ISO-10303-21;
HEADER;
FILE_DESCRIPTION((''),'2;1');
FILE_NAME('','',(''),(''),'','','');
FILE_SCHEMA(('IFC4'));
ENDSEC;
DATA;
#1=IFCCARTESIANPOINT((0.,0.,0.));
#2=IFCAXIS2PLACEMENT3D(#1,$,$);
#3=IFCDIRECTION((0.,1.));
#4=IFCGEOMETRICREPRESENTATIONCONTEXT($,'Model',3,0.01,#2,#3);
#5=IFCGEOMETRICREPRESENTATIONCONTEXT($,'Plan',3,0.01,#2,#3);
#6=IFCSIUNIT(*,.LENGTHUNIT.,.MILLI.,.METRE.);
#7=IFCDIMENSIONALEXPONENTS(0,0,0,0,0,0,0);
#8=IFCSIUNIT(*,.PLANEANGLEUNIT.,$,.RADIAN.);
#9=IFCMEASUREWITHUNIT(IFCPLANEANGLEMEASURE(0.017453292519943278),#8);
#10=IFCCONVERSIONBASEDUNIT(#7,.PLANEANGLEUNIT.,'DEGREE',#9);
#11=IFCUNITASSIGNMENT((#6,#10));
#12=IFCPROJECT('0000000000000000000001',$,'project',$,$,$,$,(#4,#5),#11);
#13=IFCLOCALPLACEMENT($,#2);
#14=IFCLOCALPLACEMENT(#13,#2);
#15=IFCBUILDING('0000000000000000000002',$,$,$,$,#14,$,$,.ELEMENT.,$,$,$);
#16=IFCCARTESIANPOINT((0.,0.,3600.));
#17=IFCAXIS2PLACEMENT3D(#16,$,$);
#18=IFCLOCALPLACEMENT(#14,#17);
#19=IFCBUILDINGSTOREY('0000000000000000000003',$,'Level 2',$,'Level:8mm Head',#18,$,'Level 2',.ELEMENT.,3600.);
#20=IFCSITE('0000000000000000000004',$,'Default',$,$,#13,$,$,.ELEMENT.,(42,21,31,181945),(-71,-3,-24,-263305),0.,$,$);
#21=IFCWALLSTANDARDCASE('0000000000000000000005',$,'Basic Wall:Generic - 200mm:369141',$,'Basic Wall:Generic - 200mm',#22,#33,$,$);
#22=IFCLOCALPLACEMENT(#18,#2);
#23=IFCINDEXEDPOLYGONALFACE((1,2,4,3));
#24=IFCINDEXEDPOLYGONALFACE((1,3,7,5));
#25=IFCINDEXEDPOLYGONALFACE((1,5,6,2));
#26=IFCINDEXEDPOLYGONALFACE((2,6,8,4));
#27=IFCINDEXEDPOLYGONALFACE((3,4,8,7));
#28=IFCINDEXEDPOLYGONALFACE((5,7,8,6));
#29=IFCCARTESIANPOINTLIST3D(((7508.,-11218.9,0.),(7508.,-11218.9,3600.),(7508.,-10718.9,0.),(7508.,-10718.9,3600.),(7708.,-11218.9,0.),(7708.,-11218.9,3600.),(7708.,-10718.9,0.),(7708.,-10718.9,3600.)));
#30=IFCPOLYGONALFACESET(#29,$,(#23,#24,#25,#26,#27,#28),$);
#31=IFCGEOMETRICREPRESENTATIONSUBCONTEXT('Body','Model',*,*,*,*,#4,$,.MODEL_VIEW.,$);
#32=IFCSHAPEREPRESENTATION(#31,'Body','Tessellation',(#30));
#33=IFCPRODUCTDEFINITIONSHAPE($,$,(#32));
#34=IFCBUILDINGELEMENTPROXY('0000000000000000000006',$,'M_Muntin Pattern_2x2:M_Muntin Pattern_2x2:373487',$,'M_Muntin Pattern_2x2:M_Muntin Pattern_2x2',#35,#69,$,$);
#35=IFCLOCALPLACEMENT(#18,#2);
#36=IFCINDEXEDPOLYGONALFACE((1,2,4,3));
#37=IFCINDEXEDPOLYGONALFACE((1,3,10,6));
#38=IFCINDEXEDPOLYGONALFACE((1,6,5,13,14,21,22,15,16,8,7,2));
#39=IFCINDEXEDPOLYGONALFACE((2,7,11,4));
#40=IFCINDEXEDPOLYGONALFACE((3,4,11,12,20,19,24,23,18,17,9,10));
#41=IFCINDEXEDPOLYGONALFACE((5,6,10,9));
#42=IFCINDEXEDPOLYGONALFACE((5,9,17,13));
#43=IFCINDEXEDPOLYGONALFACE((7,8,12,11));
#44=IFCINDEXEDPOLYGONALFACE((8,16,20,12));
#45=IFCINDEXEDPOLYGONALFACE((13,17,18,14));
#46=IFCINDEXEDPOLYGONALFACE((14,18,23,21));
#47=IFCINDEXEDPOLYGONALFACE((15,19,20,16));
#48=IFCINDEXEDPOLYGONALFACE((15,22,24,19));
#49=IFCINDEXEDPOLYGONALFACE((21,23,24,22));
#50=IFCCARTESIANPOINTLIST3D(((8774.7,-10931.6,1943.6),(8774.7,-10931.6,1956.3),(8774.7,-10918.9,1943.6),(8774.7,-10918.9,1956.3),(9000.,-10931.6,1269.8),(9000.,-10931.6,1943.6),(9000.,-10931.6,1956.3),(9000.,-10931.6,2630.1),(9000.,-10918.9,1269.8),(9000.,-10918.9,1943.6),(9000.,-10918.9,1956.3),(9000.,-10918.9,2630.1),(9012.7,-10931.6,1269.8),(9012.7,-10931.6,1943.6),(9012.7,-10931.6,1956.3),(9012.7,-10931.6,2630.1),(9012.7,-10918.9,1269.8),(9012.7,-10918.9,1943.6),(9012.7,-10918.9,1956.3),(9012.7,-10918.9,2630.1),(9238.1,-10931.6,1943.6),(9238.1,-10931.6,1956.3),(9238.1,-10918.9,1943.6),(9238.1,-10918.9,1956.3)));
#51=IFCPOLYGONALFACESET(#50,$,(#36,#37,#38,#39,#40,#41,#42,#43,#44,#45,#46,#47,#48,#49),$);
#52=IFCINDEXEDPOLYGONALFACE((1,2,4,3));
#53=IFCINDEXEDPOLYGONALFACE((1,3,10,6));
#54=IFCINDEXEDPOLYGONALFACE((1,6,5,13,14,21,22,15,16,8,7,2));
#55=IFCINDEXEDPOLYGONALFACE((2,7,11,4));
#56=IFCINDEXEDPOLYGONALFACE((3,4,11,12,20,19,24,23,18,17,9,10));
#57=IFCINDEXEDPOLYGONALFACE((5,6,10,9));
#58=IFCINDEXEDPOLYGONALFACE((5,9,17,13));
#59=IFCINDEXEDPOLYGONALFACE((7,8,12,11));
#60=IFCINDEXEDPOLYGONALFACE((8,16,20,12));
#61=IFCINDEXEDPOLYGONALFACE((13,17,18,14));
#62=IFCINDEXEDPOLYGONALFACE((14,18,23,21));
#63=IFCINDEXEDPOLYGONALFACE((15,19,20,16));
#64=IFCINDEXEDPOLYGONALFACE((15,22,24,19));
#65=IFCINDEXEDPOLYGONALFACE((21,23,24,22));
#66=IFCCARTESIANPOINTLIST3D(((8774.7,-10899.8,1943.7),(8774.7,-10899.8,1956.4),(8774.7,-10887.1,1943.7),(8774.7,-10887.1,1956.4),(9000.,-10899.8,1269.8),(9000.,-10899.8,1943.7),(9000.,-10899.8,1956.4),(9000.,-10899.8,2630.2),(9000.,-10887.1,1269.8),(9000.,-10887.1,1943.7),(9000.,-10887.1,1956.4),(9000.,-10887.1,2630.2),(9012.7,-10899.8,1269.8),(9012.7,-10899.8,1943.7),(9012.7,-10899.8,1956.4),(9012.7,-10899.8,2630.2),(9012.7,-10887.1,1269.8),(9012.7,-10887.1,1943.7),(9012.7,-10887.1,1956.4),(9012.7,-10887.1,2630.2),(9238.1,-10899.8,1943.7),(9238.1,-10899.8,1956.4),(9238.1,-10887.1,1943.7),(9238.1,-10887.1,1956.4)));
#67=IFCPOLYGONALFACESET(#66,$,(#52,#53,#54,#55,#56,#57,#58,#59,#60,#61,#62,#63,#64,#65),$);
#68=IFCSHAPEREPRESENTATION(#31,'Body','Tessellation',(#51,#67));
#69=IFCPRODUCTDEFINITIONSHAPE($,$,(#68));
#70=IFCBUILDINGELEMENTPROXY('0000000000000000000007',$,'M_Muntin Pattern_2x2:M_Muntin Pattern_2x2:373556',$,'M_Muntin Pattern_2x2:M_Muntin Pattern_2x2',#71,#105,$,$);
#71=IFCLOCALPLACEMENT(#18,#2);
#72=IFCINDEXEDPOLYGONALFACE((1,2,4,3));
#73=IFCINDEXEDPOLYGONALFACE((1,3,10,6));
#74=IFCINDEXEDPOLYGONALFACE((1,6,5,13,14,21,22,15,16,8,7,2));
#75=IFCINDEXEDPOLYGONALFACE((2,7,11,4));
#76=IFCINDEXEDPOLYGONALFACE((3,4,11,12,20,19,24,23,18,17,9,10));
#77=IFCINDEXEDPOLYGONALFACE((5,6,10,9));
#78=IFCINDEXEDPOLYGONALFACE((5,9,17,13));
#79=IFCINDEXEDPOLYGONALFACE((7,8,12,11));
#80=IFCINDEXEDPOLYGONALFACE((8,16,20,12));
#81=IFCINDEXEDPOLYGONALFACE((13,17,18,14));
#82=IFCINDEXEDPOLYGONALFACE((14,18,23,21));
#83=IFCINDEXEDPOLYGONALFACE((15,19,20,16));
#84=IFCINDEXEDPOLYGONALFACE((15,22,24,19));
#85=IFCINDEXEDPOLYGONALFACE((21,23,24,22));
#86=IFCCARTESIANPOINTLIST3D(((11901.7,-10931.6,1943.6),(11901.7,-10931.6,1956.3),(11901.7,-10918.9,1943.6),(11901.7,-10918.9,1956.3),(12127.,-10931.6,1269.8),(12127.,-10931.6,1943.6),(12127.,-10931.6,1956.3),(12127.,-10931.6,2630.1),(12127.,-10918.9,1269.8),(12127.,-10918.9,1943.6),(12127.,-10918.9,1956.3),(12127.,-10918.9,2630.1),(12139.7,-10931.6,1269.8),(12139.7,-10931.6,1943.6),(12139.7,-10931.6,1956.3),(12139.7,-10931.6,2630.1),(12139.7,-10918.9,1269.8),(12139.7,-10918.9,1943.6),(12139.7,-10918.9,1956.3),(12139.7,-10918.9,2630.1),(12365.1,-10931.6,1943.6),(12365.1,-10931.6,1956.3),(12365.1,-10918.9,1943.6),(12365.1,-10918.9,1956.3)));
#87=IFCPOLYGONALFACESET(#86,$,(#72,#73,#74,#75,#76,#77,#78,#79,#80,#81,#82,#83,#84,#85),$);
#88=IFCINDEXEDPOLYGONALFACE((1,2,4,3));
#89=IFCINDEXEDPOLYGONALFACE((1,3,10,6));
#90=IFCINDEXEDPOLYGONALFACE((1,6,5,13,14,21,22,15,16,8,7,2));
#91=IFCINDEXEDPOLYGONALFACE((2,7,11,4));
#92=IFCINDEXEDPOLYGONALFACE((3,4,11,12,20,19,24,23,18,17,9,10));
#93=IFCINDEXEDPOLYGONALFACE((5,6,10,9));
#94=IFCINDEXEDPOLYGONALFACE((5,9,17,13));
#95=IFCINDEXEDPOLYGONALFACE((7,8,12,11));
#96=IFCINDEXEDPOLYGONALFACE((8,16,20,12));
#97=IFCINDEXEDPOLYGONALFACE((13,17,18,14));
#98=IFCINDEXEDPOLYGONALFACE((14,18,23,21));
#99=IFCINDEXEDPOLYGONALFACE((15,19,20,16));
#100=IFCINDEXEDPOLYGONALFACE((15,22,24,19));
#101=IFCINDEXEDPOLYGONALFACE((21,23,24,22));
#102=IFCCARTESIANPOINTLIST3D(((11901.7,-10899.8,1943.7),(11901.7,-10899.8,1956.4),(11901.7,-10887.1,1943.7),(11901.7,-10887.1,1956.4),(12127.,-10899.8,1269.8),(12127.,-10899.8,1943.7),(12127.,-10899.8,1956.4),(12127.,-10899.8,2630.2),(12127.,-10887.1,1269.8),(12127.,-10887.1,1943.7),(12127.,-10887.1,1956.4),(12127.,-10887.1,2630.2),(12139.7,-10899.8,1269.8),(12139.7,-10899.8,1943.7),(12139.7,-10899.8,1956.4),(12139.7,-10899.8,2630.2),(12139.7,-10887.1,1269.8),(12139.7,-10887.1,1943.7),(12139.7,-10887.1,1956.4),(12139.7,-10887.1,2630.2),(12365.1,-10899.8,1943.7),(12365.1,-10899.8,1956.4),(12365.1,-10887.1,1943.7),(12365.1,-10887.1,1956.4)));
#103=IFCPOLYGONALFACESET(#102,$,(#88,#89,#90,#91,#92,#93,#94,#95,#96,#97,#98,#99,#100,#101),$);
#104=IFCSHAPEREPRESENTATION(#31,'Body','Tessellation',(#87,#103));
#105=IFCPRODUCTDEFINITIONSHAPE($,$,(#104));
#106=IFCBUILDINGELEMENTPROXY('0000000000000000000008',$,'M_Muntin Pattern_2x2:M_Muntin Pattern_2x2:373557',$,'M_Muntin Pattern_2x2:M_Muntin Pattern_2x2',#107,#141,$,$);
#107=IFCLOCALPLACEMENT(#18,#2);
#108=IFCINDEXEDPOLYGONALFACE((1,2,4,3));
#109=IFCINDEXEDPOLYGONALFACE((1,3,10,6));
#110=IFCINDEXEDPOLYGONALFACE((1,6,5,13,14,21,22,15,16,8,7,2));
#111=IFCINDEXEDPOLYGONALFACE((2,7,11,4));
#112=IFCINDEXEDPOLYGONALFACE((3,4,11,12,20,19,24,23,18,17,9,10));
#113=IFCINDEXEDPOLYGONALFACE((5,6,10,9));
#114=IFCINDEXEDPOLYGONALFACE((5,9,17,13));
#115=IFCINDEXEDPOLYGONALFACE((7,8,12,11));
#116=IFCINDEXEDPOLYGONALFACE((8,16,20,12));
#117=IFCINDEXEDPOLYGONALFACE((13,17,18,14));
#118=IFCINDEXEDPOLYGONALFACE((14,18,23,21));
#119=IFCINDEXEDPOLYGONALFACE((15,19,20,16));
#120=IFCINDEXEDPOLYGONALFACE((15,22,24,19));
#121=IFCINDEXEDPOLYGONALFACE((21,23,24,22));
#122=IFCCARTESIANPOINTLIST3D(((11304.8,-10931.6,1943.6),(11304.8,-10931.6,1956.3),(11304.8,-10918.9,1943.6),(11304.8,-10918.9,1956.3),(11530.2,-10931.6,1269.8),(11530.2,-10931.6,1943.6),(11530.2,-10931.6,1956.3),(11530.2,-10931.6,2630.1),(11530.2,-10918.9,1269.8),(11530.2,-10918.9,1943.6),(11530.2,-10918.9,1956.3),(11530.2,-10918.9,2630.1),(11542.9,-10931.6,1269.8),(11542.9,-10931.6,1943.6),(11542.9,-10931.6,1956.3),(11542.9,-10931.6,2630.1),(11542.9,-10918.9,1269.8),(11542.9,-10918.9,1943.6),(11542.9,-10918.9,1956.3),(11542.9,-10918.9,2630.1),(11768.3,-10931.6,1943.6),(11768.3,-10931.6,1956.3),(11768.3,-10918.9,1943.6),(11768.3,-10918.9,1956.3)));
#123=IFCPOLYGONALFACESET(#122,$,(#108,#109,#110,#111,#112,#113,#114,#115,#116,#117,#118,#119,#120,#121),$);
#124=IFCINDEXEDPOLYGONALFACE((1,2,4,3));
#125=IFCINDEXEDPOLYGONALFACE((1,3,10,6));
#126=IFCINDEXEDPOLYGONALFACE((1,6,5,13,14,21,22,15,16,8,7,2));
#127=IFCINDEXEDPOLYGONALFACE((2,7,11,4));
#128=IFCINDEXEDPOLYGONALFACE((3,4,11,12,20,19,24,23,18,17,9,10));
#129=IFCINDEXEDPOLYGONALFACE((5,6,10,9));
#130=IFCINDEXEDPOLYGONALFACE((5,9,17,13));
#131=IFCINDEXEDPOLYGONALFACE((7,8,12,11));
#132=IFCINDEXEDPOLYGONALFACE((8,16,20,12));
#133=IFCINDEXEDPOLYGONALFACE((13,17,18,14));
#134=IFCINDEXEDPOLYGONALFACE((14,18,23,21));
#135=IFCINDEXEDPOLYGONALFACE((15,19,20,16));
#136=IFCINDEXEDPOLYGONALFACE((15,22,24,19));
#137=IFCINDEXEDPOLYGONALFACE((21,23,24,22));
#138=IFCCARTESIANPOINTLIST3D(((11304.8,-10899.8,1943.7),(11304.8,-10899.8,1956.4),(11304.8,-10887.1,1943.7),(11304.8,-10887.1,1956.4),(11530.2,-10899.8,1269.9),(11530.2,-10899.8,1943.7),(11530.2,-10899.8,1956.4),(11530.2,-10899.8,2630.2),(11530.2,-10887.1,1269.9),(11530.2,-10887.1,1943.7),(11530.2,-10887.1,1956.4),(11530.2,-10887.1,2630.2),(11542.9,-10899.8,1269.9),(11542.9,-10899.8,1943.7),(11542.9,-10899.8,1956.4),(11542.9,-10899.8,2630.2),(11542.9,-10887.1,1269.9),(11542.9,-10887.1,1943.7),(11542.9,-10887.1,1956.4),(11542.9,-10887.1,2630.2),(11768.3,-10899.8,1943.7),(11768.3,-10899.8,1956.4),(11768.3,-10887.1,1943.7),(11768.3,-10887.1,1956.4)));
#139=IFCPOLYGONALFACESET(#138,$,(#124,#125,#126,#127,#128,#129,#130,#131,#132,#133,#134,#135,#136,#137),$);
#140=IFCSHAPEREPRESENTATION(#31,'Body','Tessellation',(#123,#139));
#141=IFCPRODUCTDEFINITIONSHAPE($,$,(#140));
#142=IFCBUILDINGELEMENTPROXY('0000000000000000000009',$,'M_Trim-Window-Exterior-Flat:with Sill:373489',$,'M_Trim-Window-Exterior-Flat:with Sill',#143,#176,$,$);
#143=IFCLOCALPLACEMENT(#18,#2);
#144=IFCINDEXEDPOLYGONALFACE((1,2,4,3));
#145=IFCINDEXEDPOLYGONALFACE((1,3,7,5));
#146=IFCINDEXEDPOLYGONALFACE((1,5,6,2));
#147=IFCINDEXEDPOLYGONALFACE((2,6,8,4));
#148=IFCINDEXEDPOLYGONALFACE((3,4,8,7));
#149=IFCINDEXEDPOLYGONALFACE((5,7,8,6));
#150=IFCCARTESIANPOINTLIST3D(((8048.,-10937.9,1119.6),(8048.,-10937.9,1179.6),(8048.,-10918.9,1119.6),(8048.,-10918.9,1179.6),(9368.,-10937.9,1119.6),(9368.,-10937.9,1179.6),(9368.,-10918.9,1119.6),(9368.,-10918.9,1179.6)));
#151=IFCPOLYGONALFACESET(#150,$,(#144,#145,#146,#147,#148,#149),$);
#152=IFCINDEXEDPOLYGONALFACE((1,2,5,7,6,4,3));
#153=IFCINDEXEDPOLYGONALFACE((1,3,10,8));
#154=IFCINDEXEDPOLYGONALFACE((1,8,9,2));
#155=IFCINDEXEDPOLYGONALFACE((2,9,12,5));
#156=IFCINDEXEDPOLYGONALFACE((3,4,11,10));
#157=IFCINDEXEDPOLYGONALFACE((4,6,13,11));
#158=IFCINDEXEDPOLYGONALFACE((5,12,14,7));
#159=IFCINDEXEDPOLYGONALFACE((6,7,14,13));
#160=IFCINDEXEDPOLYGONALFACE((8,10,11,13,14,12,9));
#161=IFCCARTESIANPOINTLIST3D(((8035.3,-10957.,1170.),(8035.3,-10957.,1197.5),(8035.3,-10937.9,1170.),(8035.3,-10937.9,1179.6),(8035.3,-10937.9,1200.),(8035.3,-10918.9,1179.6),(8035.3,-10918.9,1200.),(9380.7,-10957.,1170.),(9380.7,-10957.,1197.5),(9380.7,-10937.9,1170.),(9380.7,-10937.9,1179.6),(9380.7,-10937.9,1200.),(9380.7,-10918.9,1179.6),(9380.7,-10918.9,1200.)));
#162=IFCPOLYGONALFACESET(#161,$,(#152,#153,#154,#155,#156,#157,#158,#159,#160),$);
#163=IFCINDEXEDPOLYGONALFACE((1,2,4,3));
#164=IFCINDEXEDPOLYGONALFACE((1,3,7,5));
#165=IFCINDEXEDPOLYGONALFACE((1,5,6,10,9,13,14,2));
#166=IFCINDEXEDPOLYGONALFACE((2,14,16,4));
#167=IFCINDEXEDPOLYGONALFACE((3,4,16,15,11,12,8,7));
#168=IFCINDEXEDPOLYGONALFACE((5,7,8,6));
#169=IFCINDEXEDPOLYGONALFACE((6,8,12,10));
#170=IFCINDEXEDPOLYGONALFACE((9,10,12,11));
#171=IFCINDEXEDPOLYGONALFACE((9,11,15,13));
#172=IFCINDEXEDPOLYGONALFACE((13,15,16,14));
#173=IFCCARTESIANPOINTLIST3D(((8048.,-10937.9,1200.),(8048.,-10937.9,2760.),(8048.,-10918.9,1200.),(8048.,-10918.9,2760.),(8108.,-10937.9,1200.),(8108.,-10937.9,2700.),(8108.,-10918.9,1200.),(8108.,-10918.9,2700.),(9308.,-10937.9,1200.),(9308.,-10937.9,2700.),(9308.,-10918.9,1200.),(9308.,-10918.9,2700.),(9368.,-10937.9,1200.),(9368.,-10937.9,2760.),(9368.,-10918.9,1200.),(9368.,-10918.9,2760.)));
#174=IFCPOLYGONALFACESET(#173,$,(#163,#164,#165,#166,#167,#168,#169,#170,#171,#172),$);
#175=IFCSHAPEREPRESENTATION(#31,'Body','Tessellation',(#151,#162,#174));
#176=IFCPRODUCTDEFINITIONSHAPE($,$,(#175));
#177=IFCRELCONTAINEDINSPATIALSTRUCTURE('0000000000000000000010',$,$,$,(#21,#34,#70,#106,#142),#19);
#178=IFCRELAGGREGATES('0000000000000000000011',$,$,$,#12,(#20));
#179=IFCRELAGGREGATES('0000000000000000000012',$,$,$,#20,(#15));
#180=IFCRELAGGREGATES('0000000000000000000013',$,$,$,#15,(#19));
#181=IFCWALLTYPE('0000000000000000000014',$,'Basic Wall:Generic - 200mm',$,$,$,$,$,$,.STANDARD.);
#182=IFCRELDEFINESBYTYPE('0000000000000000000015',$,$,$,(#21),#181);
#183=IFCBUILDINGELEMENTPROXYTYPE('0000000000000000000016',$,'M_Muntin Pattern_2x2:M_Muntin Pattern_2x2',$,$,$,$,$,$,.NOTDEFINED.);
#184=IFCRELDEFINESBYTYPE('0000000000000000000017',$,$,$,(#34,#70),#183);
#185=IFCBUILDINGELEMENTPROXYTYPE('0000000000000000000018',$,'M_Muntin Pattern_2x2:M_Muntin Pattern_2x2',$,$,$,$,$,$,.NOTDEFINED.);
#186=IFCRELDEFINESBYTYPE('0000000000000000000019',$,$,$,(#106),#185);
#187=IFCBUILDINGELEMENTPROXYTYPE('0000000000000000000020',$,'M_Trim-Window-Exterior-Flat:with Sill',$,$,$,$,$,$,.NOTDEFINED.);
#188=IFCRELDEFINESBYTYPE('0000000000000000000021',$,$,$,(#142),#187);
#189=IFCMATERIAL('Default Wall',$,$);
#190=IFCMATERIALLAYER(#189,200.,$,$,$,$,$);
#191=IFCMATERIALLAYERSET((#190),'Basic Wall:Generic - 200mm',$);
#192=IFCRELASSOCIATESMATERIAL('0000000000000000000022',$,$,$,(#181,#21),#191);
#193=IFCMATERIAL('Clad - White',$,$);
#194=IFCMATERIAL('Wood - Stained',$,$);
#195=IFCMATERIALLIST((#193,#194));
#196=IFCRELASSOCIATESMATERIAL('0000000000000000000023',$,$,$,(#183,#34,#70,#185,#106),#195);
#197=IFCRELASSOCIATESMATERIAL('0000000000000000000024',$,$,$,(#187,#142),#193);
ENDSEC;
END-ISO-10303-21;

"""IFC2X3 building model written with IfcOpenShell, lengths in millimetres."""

from ifc_helpers import new_model, entity, si_unit, converted_unit, direction, frame, frame_2d, origin, place, context, subcontext, project, spatial, polyline, rectangle, outline, extrude, source, transform, mapped, material, material_list, layer, layer_set, layer_usage, type_object, type_shapes, element, save


model = new_model("IFC2X3")

# Units and contexts
model_context = context("Model", 3, precision=0.01, world=origin(), true_north=direction((0.0, 1.0)))
plan_context = context("Plan", 3, precision=0.01, world=origin(), true_north=direction((0.0, 1.0)))
body_context = subcontext(model_context, "Body", "Model", "MODEL_VIEW")
ifc_project = project(units=[si_unit("LENGTHUNIT", "METRE", prefix="MILLI"), converted_unit("PLANEANGLEUNIT", "DEGREE", entity("IfcPlaneAngleMeasure", 0.017453292519943278), si_unit("PLANEANGLEUNIT", "RADIAN"), dimensions=[0, 0, 0, 0, 0, 0, 0])], contexts=[model_context, plan_context])

# Site, building, storey
site_placement = place(None, origin())
site = spatial("IfcSite", under=ifc_project, at=site_placement, Name="Default", CompositionType="ELEMENT", RefLatitude=(42, 21, 31, 181945), RefLongitude=(-71, -3, -24, -263305), RefElevation=0.0)
building_placement = place(site_placement, origin())
building = spatial("IfcBuilding", under=site, at=building_placement, CompositionType="ELEMENT")
storey_placement = place(building_placement, frame((0.0, 0.0, 3600.0)))
storey = spatial("IfcBuildingStorey", under=building, at=storey_placement, Name="Level 2", ObjectType="Level:8mm Head", LongName="Level 2", CompositionType="ELEMENT", Elevation=3600.0)

# Wall
ifc_material_1 = material(Name="Default Wall")
ifc_layer = layer(ifc_material_1, 200.0)
ifc_layer_set = layer_set([ifc_layer], Name="Basic Wall:Generic - 200mm")
ifc_layer_usage = layer_usage(ifc_layer_set, "AXIS2", "NEGATIVE", 100.0)
wall_type = type_object("IfcWallType", Name="Basic Wall:Generic - 200mm", PredefinedType="STANDARD", material=ifc_layer_set)
wall_placement = place(storey_placement, frame((7608.0, -11218.9, 0.0), z_axis=(0.0, 0.0, 1.0), x_axis=(0.0, 1.0, 0.0)))
element("IfcWallStandardCase", 1, at=wall_placement, inside=storey, type_object=wall_type, material=ifc_layer_usage, Name="Basic Wall:Generic - 200mm:369141", ObjectType="Basic Wall:Generic - 200mm", context=body_context, shape_type="SweptSolid", body=[
    extrude(rectangle(XDim=500.0, YDim=200.0, at=frame_2d((250.0, 0.0), x_axis=(-1.0, 0.0))), origin(), (0.0, 0.0, 1.0), 3600.0),
])

# Building element proxies
ifc_material_2 = material(Name="Clad - White")
ifc_material_3 = material(Name="Wood - Stained")
ifc_material_list = material_list([ifc_material_2, ifc_material_3])
building_element_proxy_type_1 = type_object("IfcBuildingElementProxyType", Name="M_Muntin Pattern_2x2:M_Muntin Pattern_2x2", PredefinedType="NOTDEFINED", material=ifc_material_list)
shared_shape_1 = source(origin(), body_context, "Body", "SweptSolid", [
    extrude(outline(polyline([(6.4, -6.4), (680.1, -6.4), (680.1, 6.3), (6.4, 6.3), (6.4, 231.7), (-6.3, 231.7), (-6.3, 6.3), (-680.2, 6.3), (-680.2, -6.4), (-6.3, -6.4), (-6.3, -231.7), (6.4, -231.7), (6.4, -6.4)])), frame((0.0, 9.5, 680.1), z_axis=(0.0, 1.0, 0.0), x_axis=(0.0, 0.0, 1.0)), (0.0, 0.0, 1.0), 12.7),
    extrude(outline(polyline([(6.4, -6.4), (680.2, -6.4), (680.2, 6.3), (6.4, 6.3), (6.4, 231.7), (-6.3, 231.7), (-6.3, 6.3), (-680.2, 6.3), (-680.2, -6.4), (-6.3, -6.4), (-6.3, -231.7), (6.4, -231.7), (6.4, -6.4)])), frame((0.0, -22.2, 680.2), z_axis=(0.0, 1.0, 0.0), x_axis=(0.0, 0.0, 1.0)), (0.0, 0.0, 1.0), 12.7),
])
type_shapes(building_element_proxy_type_1, [shared_shape_1])
for number, where, z_axis, x_axis, name in (
    (2, (9006.4, -10909.4, 1269.8), (0.0, 0.0, 1.0), (-1.0, 0.0, 0.0), "M_Muntin Pattern_2x2:M_Muntin Pattern_2x2:373487"),
    (3, (12133.4, -10909.4, 1269.8), (0.0, 0.0, 1.0), (-1.0, 0.0, 0.0), "M_Muntin Pattern_2x2:M_Muntin Pattern_2x2:373556"),
):
    element("IfcBuildingElementProxy", number, at=place(storey_placement, frame(where, z_axis=z_axis, x_axis=x_axis)), inside=storey, type_object=building_element_proxy_type_1, material=ifc_material_list, Name=name, ObjectType="M_Muntin Pattern_2x2:M_Muntin Pattern_2x2", context=body_context, shape_type="MappedRepresentation", body=[
        mapped(shared_shape_1, transform((0.0, 0.0, 0.0), scale=1.0)),
    ])
building_element_proxy_type_2 = type_object("IfcBuildingElementProxyType", Name="M_Muntin Pattern_2x2:M_Muntin Pattern_2x2", PredefinedType="NOTDEFINED", material=ifc_material_list)
shared_shape_2 = source(origin(), body_context, "Body", "SweptSolid", [
    extrude(outline(polyline([(6.4, -6.4), (680.1, -6.4), (680.1, 6.3), (6.4, 6.3), (6.4, 231.7), (-6.3, 231.7), (-6.3, 6.3), (-680.2, 6.3), (-680.2, -6.4), (-6.3, -6.4), (-6.3, -231.7), (6.4, -231.7), (6.4, -6.4)])), frame((0.0, -22.2, 680.1), z_axis=(0.0, 1.0, 0.0), x_axis=(0.0, 0.0, 1.0)), (0.0, 0.0, 1.0), 12.7),
    extrude(outline(polyline([(6.4, -6.4), (680.2, -6.4), (680.2, 6.3), (6.4, 6.3), (6.4, 231.7), (-6.3, 231.7), (-6.3, 6.3), (-680.2, 6.3), (-680.2, -6.4), (-6.3, -6.4), (-6.3, -231.7), (6.4, -231.7), (6.4, -6.4)])), frame((0.0, 9.5, 680.2), z_axis=(0.0, 1.0, 0.0), x_axis=(0.0, 0.0, 1.0)), (0.0, 0.0, 1.0), 12.7),
])
type_shapes(building_element_proxy_type_2, [shared_shape_2])
proxy_placement = place(storey_placement, frame((11536.6, -10909.4, 1269.9)))
element("IfcBuildingElementProxy", 4, at=proxy_placement, inside=storey, type_object=building_element_proxy_type_2, material=ifc_material_list, Name="M_Muntin Pattern_2x2:M_Muntin Pattern_2x2:373557", ObjectType="M_Muntin Pattern_2x2:M_Muntin Pattern_2x2", context=body_context, shape_type="MappedRepresentation", body=[
    mapped(shared_shape_2, transform((0.0, 0.0, 0.0), scale=1.0)),
])
building_element_proxy_type_3 = type_object("IfcBuildingElementProxyType", Name="M_Trim-Window-Exterior-Flat:with Sill", PredefinedType="NOTDEFINED", material=ifc_material_2)
shared_shape_3 = source(origin(), body_context, "Body", "SweptSolid", [
    extrude(rectangle(XDim=1320.0, YDim=60.0, at=frame_2d((0.0, 0.0), x_axis=(1.0, 0.0))), frame((0.0, -1550.4, 0.0), z_axis=(0.0, 0.0, 1.0), x_axis=(-1.0, 0.0, 0.0)), (0.0, 0.0, 1.0), 19.0),
    extrude(outline(polyline([(-19.0, -15.2), (0.0, -15.2), (0.0, -5.7), (19.0, -5.7), (19.0, 14.8), (0.0, 14.8), (-19.0, 12.3), (-19.0, -15.2)])), frame((-672.7, -1514.8, 19.0), z_axis=(1.0, 0.0, 0.0), x_axis=(0.0, 0.0, -1.0)), (0.0, 0.0, 1.0), 1345.4),
    extrude(outline(polyline([(-795.0, -660.0), (765.0, -660.0), (765.0, -600.0), (-735.0, -600.0), (-735.0, 600.0), (765.0, 600.0), (765.0, 660.0), (-795.0, 660.0), (-795.0, -660.0)])), frame((0.0, -735.0, 0.0), z_axis=(0.0, 0.0, 1.0), x_axis=(0.0, -1.0, 0.0)), (0.0, 0.0, 1.0), 19.0),
])
type_shapes(building_element_proxy_type_3, [shared_shape_3])
for number, where, z_axis, x_axis, name in (
    (5, (8708.0, -10918.9, 2700.0), (0.0, -1.0, 0.0), (1.0, 0.0, 0.0), "M_Trim-Window-Exterior-Flat:with Sill:373489"),
):
    element("IfcBuildingElementProxy", number, at=place(storey_placement, frame(where, z_axis=z_axis, x_axis=x_axis)), inside=storey, type_object=building_element_proxy_type_3, material=ifc_material_2, Name=name, ObjectType="M_Trim-Window-Exterior-Flat:with Sill", context=body_context, shape_type="MappedRepresentation", body=[
        mapped(shared_shape_3, transform((0.0, 0.0, 0.0), scale=1.0)),
    ])

save(model, "model.ifc")
